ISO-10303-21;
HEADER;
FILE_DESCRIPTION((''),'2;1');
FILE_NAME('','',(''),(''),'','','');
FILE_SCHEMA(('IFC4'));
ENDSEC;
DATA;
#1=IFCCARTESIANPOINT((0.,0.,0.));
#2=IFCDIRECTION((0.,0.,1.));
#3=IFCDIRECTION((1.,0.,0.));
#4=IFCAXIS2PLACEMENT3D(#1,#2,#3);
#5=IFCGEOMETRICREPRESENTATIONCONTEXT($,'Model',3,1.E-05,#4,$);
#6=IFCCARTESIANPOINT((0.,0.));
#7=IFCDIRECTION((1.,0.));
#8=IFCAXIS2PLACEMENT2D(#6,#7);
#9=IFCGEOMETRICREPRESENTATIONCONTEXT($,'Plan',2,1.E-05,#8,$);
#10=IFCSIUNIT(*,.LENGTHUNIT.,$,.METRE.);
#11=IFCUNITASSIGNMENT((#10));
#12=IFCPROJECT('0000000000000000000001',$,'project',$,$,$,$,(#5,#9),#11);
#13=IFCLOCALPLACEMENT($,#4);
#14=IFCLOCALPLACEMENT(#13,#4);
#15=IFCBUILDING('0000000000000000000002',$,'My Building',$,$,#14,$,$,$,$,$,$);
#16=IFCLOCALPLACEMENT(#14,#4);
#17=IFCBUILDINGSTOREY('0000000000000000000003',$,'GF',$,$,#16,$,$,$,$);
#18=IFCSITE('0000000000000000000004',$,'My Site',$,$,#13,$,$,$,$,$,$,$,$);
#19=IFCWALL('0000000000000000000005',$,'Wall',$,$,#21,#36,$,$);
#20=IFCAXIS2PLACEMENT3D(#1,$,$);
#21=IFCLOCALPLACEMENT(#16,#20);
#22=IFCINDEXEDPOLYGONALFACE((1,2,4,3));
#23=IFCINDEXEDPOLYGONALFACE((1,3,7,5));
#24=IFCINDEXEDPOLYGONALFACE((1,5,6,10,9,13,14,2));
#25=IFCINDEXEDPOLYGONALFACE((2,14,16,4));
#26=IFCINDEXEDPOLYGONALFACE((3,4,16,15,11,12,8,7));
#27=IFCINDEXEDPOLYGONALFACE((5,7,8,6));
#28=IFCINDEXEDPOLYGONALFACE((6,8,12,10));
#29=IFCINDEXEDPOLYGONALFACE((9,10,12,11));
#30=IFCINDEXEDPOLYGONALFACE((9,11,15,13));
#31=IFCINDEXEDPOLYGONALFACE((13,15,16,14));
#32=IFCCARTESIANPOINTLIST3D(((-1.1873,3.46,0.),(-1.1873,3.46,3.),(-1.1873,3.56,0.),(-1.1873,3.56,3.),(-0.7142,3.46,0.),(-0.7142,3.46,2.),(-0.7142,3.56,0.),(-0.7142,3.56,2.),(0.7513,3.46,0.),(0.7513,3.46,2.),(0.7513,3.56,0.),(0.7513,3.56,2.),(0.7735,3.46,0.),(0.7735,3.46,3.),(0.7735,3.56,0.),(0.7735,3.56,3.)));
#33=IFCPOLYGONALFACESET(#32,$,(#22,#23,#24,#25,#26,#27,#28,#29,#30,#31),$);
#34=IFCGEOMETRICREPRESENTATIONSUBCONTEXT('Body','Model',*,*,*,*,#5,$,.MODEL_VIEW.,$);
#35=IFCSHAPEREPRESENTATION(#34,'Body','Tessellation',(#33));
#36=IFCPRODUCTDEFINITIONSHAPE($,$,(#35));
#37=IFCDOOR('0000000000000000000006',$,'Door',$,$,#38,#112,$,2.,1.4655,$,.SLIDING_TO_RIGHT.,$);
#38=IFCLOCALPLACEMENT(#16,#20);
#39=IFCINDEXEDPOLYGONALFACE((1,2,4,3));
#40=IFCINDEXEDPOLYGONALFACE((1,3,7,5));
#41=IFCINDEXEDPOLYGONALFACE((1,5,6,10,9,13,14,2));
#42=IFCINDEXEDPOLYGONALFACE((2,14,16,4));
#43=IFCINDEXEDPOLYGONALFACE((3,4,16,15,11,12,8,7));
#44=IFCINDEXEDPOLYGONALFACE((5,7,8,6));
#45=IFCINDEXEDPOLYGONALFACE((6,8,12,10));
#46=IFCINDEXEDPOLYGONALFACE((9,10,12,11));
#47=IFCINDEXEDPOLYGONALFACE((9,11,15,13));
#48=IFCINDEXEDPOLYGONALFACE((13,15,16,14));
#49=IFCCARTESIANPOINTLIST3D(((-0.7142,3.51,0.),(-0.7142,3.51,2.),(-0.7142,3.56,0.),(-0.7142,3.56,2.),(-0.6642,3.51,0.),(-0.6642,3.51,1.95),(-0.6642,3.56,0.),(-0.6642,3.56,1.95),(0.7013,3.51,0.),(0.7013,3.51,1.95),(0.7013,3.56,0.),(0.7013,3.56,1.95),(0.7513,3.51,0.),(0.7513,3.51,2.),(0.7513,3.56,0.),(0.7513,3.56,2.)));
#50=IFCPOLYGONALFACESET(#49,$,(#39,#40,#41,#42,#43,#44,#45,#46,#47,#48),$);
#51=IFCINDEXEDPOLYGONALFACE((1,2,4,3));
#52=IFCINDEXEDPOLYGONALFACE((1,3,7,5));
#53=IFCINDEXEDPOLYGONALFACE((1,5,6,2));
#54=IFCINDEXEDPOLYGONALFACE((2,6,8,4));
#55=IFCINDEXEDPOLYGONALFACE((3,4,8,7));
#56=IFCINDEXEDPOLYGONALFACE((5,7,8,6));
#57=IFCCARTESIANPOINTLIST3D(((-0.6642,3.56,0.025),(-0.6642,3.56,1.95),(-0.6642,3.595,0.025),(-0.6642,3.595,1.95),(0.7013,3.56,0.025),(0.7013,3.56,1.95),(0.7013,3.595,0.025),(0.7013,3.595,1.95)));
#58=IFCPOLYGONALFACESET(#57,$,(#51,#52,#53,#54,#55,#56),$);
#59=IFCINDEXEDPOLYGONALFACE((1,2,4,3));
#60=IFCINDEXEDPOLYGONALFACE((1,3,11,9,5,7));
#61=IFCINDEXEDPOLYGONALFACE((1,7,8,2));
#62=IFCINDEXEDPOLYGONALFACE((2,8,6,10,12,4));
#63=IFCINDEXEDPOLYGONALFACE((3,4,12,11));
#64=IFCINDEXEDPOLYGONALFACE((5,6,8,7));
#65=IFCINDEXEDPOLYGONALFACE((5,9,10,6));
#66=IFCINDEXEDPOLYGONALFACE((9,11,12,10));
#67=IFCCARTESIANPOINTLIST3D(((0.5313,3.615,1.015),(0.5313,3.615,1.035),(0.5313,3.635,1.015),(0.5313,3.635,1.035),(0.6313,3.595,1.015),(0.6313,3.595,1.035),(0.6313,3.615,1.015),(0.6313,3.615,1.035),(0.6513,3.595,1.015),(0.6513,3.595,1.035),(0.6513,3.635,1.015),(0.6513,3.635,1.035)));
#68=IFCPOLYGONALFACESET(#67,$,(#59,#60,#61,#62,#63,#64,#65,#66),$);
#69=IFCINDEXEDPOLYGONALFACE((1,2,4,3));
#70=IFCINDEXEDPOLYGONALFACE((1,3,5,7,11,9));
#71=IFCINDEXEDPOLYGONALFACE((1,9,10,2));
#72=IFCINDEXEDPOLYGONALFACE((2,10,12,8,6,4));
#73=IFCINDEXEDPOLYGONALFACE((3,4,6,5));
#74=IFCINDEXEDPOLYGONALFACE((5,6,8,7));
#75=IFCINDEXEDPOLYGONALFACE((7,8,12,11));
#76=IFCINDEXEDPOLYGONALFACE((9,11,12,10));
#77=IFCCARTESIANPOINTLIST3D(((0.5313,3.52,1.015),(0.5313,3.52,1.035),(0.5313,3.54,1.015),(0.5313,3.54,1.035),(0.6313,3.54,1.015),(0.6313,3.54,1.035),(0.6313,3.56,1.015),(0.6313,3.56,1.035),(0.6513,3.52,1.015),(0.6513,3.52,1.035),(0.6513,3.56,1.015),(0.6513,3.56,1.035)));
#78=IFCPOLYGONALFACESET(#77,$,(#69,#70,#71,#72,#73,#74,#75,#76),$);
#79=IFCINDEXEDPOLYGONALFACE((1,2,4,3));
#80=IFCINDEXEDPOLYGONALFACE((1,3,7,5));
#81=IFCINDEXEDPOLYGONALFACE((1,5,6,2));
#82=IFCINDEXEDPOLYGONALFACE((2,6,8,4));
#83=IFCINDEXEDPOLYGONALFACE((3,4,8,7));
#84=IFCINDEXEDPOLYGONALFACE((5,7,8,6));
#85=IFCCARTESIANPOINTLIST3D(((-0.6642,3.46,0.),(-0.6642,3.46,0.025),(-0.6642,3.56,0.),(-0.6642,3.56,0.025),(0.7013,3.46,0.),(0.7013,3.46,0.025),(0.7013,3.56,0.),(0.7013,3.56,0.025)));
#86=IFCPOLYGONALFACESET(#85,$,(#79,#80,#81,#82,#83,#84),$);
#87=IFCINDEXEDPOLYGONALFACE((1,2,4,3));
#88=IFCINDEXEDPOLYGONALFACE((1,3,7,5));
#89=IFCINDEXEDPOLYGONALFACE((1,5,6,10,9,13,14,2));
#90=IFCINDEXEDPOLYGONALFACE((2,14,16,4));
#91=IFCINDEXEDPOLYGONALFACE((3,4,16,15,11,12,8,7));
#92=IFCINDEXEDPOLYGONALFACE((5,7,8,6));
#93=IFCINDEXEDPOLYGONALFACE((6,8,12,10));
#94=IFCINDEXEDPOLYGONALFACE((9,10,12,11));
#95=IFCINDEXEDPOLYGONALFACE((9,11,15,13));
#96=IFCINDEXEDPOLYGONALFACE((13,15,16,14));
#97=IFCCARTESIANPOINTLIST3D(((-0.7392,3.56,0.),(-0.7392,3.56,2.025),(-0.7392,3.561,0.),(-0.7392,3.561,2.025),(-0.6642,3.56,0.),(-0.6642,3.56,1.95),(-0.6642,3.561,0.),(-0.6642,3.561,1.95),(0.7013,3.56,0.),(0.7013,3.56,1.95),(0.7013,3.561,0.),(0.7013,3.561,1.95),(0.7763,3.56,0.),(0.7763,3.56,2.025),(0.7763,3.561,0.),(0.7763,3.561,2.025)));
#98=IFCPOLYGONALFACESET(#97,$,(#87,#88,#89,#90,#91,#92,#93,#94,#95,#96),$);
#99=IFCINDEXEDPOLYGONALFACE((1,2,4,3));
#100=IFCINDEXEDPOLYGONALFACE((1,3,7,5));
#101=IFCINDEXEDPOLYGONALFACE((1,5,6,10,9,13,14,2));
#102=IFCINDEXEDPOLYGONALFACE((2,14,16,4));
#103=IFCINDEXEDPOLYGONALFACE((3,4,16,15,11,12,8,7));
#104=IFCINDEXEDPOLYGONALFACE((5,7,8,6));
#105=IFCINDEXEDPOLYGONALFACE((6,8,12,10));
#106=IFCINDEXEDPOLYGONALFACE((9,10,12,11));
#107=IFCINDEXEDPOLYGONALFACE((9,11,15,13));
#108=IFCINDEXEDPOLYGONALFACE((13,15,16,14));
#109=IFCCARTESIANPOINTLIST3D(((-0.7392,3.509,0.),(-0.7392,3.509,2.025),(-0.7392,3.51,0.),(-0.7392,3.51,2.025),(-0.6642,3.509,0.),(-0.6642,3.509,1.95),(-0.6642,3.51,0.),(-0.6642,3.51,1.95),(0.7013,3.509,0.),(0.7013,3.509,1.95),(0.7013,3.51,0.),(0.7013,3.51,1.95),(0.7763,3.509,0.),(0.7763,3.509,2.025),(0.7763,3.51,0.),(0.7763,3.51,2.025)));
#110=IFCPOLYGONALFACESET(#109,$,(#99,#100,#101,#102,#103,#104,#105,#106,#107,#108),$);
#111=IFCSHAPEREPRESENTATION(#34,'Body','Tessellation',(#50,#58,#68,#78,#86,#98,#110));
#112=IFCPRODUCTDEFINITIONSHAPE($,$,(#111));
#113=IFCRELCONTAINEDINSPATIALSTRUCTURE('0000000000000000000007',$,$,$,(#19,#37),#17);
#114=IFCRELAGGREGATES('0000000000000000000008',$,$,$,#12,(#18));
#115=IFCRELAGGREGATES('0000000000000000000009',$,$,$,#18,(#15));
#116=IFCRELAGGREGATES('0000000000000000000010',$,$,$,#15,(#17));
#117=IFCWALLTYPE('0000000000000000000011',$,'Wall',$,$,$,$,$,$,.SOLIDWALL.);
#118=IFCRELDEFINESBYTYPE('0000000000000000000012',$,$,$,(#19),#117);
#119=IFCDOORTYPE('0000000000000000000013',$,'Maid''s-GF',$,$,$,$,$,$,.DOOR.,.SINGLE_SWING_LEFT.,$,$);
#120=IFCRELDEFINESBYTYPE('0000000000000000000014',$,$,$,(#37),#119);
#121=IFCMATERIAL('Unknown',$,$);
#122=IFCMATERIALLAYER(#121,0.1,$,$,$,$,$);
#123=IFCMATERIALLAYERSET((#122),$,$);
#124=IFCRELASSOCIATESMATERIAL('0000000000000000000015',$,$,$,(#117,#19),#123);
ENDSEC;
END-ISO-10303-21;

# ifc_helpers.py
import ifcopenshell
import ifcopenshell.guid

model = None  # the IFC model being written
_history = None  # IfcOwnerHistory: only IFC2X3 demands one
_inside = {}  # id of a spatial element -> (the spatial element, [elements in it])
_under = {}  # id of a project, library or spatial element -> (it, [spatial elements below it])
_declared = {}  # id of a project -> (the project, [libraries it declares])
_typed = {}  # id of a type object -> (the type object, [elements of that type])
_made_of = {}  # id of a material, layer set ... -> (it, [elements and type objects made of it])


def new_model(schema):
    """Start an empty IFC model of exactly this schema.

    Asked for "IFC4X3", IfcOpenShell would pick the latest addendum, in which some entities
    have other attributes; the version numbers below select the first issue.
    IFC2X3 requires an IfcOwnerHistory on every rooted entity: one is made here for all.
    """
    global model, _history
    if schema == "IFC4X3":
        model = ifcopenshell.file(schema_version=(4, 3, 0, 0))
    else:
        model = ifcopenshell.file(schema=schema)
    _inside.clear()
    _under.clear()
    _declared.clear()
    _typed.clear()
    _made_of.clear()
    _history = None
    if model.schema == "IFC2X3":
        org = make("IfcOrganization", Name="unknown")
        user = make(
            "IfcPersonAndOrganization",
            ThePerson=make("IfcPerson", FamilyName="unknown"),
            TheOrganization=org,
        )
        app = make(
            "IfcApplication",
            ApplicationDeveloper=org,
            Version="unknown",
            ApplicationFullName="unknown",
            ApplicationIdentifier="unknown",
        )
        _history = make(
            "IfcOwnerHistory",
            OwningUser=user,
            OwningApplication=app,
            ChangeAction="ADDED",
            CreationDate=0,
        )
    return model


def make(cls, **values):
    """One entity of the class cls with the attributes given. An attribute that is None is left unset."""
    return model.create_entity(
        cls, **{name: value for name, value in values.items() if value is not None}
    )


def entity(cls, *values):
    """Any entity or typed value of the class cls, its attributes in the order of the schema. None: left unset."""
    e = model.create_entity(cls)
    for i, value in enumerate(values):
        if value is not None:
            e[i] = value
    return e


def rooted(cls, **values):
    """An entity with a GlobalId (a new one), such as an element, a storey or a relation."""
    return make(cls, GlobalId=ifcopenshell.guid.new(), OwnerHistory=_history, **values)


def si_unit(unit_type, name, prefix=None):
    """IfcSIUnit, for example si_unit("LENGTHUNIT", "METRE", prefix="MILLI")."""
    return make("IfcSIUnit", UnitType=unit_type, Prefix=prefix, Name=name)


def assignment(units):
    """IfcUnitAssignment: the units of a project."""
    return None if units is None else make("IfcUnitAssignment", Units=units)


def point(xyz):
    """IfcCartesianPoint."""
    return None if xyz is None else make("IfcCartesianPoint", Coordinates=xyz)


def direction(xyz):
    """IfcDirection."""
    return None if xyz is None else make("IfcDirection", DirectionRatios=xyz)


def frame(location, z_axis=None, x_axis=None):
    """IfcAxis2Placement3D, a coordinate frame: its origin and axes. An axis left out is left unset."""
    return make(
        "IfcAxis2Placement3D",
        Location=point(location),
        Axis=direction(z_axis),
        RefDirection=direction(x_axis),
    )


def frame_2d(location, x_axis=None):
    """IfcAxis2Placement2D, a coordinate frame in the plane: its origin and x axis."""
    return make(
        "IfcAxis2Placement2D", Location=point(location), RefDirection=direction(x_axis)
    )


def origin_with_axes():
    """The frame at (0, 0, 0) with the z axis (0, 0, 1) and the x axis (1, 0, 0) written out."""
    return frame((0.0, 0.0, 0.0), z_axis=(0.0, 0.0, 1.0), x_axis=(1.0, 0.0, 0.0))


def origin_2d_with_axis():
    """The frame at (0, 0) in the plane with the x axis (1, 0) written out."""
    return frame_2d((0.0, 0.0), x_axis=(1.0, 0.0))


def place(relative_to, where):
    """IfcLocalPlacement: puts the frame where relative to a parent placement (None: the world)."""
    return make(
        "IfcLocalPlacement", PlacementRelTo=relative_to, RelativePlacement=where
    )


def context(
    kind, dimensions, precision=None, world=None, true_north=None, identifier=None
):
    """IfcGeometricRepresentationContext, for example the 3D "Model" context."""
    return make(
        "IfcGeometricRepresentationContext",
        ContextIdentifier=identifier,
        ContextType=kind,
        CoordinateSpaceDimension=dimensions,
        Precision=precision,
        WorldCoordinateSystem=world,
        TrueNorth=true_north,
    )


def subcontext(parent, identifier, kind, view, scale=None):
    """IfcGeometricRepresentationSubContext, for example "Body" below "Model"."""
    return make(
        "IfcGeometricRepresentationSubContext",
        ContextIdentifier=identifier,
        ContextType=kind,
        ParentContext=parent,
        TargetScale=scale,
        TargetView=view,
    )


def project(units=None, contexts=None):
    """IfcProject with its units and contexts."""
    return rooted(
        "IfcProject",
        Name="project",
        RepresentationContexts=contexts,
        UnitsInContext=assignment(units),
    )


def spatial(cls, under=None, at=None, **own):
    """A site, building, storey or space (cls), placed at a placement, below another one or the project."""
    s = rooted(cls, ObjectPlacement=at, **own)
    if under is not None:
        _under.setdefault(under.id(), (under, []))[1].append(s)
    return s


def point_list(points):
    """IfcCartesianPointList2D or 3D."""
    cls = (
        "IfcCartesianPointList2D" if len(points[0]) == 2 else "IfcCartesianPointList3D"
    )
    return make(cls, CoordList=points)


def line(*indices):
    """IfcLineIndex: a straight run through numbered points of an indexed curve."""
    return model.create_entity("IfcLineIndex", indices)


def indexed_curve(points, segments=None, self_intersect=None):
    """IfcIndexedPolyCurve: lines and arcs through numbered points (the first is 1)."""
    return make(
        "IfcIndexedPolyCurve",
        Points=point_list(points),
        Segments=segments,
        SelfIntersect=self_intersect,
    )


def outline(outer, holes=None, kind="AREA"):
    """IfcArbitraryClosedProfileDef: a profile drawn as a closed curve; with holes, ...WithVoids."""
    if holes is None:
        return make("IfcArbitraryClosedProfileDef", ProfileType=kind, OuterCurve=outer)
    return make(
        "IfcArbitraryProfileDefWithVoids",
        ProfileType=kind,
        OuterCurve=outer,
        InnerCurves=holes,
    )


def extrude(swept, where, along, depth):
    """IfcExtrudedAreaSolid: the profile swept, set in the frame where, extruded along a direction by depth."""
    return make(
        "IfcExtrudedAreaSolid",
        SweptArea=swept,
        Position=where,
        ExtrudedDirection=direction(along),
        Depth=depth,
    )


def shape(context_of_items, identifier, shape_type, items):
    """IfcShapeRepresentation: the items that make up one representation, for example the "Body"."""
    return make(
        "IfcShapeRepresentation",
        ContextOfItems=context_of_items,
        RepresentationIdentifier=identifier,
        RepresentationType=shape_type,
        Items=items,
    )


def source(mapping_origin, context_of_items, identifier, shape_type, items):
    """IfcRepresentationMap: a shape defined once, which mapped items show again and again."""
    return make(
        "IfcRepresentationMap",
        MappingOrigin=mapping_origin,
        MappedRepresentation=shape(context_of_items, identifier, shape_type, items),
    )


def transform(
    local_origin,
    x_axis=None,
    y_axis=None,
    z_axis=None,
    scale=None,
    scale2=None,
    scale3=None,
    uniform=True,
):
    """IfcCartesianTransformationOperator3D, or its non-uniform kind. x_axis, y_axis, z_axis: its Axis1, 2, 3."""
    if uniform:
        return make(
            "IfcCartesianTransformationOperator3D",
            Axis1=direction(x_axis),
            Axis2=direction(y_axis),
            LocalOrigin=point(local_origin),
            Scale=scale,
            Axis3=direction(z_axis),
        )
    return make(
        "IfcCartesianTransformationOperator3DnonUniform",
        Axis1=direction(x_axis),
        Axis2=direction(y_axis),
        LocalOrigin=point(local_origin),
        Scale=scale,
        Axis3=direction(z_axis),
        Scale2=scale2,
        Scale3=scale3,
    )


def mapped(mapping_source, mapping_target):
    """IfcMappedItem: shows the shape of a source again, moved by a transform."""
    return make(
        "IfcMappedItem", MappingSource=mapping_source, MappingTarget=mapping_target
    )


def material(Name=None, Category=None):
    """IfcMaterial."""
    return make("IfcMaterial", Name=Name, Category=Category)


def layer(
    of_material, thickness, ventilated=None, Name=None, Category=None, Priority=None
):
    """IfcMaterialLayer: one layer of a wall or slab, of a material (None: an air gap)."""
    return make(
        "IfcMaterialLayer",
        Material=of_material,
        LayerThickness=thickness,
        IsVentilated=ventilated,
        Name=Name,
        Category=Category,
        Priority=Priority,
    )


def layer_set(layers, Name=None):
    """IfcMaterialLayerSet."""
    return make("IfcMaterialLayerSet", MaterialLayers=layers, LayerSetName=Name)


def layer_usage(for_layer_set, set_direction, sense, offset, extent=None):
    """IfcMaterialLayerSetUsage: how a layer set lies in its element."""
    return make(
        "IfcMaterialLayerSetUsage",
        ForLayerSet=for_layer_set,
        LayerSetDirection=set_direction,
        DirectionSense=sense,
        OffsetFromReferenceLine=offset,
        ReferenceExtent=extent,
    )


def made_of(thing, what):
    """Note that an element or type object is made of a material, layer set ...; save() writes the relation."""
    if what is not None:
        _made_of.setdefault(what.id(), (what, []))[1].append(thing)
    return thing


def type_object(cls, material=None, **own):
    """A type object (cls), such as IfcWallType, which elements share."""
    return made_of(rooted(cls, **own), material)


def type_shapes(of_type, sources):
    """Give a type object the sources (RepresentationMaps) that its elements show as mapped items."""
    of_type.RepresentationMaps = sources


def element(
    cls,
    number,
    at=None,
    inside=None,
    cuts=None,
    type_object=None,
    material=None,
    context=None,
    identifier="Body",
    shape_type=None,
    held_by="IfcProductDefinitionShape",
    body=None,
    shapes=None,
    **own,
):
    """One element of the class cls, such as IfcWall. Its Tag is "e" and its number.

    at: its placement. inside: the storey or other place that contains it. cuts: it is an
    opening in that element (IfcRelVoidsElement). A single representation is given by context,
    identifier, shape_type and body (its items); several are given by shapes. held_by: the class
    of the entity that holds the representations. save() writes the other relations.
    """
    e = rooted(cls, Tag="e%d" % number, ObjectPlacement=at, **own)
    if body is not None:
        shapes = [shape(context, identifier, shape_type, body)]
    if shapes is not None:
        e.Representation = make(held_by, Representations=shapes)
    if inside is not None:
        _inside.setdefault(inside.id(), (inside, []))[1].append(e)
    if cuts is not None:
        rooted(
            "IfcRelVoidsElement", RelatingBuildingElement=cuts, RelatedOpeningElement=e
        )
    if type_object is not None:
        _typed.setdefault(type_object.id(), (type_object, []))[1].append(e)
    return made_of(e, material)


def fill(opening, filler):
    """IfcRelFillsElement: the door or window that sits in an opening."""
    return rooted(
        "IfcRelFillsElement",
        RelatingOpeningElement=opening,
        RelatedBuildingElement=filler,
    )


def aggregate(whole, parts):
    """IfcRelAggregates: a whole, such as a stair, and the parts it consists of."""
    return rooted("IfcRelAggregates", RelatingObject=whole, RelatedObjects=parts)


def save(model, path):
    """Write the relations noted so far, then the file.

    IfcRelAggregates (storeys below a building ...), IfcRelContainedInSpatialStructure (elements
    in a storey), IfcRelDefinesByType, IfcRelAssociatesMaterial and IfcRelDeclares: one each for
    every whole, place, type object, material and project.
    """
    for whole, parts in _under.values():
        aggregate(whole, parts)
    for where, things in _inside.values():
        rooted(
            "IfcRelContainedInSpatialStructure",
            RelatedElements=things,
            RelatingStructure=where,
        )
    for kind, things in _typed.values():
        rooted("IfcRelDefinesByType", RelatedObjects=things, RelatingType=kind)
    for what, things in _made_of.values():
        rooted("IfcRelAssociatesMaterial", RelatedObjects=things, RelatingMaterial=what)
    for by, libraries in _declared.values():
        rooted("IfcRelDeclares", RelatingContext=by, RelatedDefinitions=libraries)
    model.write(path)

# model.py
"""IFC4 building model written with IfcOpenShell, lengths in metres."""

from ifc_helpers import new_model, entity, si_unit, frame, origin_with_axes, origin_2d_with_axis, place, context, subcontext, project, spatial, line, indexed_curve, outline, extrude, shape, source, transform, mapped, material, layer, layer_set, layer_usage, type_object, type_shapes, element, fill, save


model = new_model("IFC4")

# Units and contexts
model_context = context("Model", 3, precision=1e-05, world=origin_with_axes())
plan_context = context("Plan", 2, precision=1e-05, world=origin_2d_with_axis())
body_context_1 = subcontext(model_context, "Body", "Model", "MODEL_VIEW")
body_context_2 = subcontext(plan_context, "Body", "Plan", "PLAN_VIEW")
ifc_project = project(units=[si_unit("LENGTHUNIT", "METRE")], contexts=[model_context, plan_context])

# Site, building, storey
site_placement = place(None, origin_with_axes())
site = spatial("IfcSite", under=ifc_project, at=site_placement, Name="My Site")
building_placement = place(site_placement, origin_with_axes())
building = spatial("IfcBuilding", under=site, at=building_placement, Name="My Building")
storey_placement = place(building_placement, origin_with_axes())
storey = spatial("IfcBuildingStorey", under=building, at=storey_placement, Name="GF")

# Shared definitions
ifc_material_1 = material(Name="Unknown")

# Shared definitions
ifc_layer_1 = layer(ifc_material_1, 0.1)
ifc_layer_set_1 = layer_set([ifc_layer_1])
wall_type = type_object("IfcWallType", Name="Wall", PredefinedType="SOLIDWALL", material=ifc_layer_set_1)

# Wall, opening, door
ifc_layer_usage_1 = layer_usage(ifc_layer_set_1, "AXIS2", "POSITIVE", 0.0)
wall_1_placement = place(storey_placement, frame((0.7735, 3.56, 0.0), z_axis=(0.0, 0.0, 1.0), x_axis=(-1.0, 0.0, 0.0)))
wall_1 = element("IfcWall", 1, at=wall_1_placement, inside=storey, type_object=wall_type, material=ifc_layer_usage_1, Name="Wall", context=body_context_1, shape_type="SweptSolid", body=[
    extrude(outline(indexed_curve([(0.0, 0.0), (0.0, 0.1), (1.9608, 0.1), (1.9608, 0.0)], segments=[line(1, 2, 3, 4, 1)])), origin_with_axes(), (0.0, 0.0, 1.0), 3.0),
])
shared_shape_1 = source(origin_with_axes(), body_context_1, "Body", "SweptSolid", [
    extrude(outline(indexed_curve([(0.0, 0.0), (1.4655, 0.0), (1.4655, 2.0), (0.0, 2.0)], segments=[line(1, 2, 3, 4, 1)])), frame((0.0, -0.6, 0.0), z_axis=(0.0, -1.0, 0.0), x_axis=(1.0, 0.0, 0.0)), (0.0, 0.0, -1.0), 1.2),
])
opening_1_placement = place(wall_1_placement, frame((0.0222, 0.0, 0.0), z_axis=(0.0, 0.0, 1.0), x_axis=(1.0, 0.0, 0.0)))
opening_1 = element("IfcOpeningElement", 2, at=opening_1_placement, cuts=wall_1, PredefinedType="OPENING", context=body_context_1, shape_type="MappedRepresentation", body=[
    mapped(shared_shape_1, transform((0.0, 0.0, 0.0), x_axis=(1.0, 0.0, 0.0), y_axis=(0.0, 1.0, 0.0), z_axis=(0.0, 0.0, 1.0), scale=1.0)),
])
door_type_1 = type_object("IfcDoorType", Name="Maid's-GF", OperationType="SINGLE_SWING_LEFT", PredefinedType="DOOR")
shared_shape_2 = source(origin_with_axes(), body_context_1, "Body", "SweptSolid", [
    extrude(outline(indexed_curve([(0.0, 0.0), (0.0, 2.0), (1.4655, 2.0), (1.4655, 0.0), (1.4155, 0.0), (1.4155, 1.95), (0.05, 1.95), (0.05, 0.0)], segments=[line(1, 2, 3, 4, 5, 6, 7, 8, 1)])), frame((0.0, 0.0, 0.0), z_axis=(0.0, -1.0, 0.0), x_axis=(1.0, 0.0, 0.0)), (0.0, 0.0, -1.0), 0.05),
    extrude(outline(indexed_curve([(0.0, 0.0), (1.3655, 0.0), (1.3655, 0.035), (0.0, 0.035)], segments=[line(1, 2, 3, 4, 1)])), frame((0.05, -0.035, 0.025), z_axis=(0.0, 0.0, 1.0), x_axis=(1.0, 0.0, 0.0)), (0.0, 0.0, 1.0), 1.925),
    extrude(outline(indexed_curve([(0.0, 0.0), (0.0, -0.04), (0.12, -0.04), (0.12, -0.02), (0.02, -0.02), (0.02, 0.0)], segments=[line(1, 2, 3, 4, 5, 6, 1)])), frame((0.1, -0.035, 1.015), z_axis=(0.0, 0.0, 1.0), x_axis=(1.0, 0.0, 0.0)), (0.0, 0.0, 1.0), 0.02),
    extrude(outline(indexed_curve([(0.0, 0.0), (0.0, 0.04), (0.12, 0.04), (0.12, 0.02), (0.02, 0.02), (0.02, 0.0)], segments=[line(1, 2, 3, 4, 5, 6, 1)])), frame((0.1, 0.0, 1.015), z_axis=(0.0, 0.0, 1.0), x_axis=(1.0, 0.0, 0.0)), (0.0, 0.0, 1.0), 0.02),
    extrude(outline(indexed_curve([(0.0, 0.0), (1.3655, 0.0), (1.3655, 0.1), (0.0, 0.1)], segments=[line(1, 2, 3, 4, 1)])), frame((0.05, 0.0, 0.0), z_axis=(0.0, 0.0, 1.0), x_axis=(1.0, 0.0, 0.0)), (0.0, 0.0, 1.0), 0.025),
    extrude(outline(indexed_curve([(0.0, 0.0), (0.0, 2.025), (1.5155, 2.025), (1.5155, 0.0), (1.4405, 0.0), (1.4405, 1.95), (0.075, 1.95), (0.075, 0.0)], segments=[line(1, 2, 3, 4, 5, 6, 7, 8, 1)])), frame((-0.025, -0.001, 0.0), z_axis=(0.0, -1.0, 0.0), x_axis=(1.0, 0.0, 0.0)), (0.0, 0.0, -1.0), 0.001),
    extrude(outline(indexed_curve([(0.0, 0.0), (0.0, 2.025), (1.5155, 2.025), (1.5155, 0.0), (1.4405, 0.0), (1.4405, 1.95), (0.075, 1.95), (0.075, 0.0)], segments=[line(1, 2, 3, 4, 5, 6, 7, 8, 1)])), frame((-0.025, 0.05, 0.0), z_axis=(0.0, -1.0, 0.0), x_axis=(1.0, 0.0, 0.0)), (0.0, 0.0, -1.0), 0.001),
])
shared_shape_3 = source(origin_with_axes(), body_context_2, "Body", "Curve2D", [
    entity("IfcIndexedPolyCurve", entity("IfcCartesianPointList2D", [[0.0, 0.0], [0.05, 0.0], [0.05, 0.05], [0.0, 0.05]]), [entity("IfcLineIndex", [1, 2, 3, 4, 1])]),
    entity("IfcIndexedPolyCurve", entity("IfcCartesianPointList2D", [[1.4655, 0.0], [1.4155, 0.0], [1.4155, 0.05], [1.4655, 0.05]]), [entity("IfcLineIndex", [1, 2, 3, 4, 1])]),
    entity("IfcIndexedPolyCurve", entity("IfcCartesianPointList2D", [[2.0983, -0.035], [0.7328, -0.035], [0.7328, 0.0], [2.0983, 0.0]]), [entity("IfcLineIndex", [1, 2, 3, 4, 1])]),
])
type_shapes(door_type_1, [shared_shape_2, shared_shape_3])
door_1_placement = place(opening_1_placement, frame((0.0, 0.0, 0.0), z_axis=(0.0, 0.0, 1.0), x_axis=(1.0, 0.0, 0.0)))
door_1 = element("IfcDoor", 3, at=door_1_placement, inside=storey, type_object=door_type_1, Name="Door", OperationType="SLIDING_TO_RIGHT", OverallHeight=2.0, OverallWidth=1.4655, shapes=[
    shape(body_context_1, "Body", "MappedRepresentation", [mapped(shared_shape_2, transform((0.0, 0.0, 0.0), x_axis=(1.0, 0.0, 0.0), y_axis=(0.0, 1.0, 0.0), z_axis=(0.0, 0.0, 1.0), scale=1.0))]),
    shape(body_context_2, "Body", "MappedRepresentation", [mapped(shared_shape_3, transform((0.0, 0.0, 0.0), x_axis=(1.0, 0.0, 0.0), y_axis=(0.0, 1.0, 0.0), z_axis=(0.0, 0.0, 1.0), scale=1.0))]),
])
fill(opening_1, door_1)

save(model, "model.ifc")
